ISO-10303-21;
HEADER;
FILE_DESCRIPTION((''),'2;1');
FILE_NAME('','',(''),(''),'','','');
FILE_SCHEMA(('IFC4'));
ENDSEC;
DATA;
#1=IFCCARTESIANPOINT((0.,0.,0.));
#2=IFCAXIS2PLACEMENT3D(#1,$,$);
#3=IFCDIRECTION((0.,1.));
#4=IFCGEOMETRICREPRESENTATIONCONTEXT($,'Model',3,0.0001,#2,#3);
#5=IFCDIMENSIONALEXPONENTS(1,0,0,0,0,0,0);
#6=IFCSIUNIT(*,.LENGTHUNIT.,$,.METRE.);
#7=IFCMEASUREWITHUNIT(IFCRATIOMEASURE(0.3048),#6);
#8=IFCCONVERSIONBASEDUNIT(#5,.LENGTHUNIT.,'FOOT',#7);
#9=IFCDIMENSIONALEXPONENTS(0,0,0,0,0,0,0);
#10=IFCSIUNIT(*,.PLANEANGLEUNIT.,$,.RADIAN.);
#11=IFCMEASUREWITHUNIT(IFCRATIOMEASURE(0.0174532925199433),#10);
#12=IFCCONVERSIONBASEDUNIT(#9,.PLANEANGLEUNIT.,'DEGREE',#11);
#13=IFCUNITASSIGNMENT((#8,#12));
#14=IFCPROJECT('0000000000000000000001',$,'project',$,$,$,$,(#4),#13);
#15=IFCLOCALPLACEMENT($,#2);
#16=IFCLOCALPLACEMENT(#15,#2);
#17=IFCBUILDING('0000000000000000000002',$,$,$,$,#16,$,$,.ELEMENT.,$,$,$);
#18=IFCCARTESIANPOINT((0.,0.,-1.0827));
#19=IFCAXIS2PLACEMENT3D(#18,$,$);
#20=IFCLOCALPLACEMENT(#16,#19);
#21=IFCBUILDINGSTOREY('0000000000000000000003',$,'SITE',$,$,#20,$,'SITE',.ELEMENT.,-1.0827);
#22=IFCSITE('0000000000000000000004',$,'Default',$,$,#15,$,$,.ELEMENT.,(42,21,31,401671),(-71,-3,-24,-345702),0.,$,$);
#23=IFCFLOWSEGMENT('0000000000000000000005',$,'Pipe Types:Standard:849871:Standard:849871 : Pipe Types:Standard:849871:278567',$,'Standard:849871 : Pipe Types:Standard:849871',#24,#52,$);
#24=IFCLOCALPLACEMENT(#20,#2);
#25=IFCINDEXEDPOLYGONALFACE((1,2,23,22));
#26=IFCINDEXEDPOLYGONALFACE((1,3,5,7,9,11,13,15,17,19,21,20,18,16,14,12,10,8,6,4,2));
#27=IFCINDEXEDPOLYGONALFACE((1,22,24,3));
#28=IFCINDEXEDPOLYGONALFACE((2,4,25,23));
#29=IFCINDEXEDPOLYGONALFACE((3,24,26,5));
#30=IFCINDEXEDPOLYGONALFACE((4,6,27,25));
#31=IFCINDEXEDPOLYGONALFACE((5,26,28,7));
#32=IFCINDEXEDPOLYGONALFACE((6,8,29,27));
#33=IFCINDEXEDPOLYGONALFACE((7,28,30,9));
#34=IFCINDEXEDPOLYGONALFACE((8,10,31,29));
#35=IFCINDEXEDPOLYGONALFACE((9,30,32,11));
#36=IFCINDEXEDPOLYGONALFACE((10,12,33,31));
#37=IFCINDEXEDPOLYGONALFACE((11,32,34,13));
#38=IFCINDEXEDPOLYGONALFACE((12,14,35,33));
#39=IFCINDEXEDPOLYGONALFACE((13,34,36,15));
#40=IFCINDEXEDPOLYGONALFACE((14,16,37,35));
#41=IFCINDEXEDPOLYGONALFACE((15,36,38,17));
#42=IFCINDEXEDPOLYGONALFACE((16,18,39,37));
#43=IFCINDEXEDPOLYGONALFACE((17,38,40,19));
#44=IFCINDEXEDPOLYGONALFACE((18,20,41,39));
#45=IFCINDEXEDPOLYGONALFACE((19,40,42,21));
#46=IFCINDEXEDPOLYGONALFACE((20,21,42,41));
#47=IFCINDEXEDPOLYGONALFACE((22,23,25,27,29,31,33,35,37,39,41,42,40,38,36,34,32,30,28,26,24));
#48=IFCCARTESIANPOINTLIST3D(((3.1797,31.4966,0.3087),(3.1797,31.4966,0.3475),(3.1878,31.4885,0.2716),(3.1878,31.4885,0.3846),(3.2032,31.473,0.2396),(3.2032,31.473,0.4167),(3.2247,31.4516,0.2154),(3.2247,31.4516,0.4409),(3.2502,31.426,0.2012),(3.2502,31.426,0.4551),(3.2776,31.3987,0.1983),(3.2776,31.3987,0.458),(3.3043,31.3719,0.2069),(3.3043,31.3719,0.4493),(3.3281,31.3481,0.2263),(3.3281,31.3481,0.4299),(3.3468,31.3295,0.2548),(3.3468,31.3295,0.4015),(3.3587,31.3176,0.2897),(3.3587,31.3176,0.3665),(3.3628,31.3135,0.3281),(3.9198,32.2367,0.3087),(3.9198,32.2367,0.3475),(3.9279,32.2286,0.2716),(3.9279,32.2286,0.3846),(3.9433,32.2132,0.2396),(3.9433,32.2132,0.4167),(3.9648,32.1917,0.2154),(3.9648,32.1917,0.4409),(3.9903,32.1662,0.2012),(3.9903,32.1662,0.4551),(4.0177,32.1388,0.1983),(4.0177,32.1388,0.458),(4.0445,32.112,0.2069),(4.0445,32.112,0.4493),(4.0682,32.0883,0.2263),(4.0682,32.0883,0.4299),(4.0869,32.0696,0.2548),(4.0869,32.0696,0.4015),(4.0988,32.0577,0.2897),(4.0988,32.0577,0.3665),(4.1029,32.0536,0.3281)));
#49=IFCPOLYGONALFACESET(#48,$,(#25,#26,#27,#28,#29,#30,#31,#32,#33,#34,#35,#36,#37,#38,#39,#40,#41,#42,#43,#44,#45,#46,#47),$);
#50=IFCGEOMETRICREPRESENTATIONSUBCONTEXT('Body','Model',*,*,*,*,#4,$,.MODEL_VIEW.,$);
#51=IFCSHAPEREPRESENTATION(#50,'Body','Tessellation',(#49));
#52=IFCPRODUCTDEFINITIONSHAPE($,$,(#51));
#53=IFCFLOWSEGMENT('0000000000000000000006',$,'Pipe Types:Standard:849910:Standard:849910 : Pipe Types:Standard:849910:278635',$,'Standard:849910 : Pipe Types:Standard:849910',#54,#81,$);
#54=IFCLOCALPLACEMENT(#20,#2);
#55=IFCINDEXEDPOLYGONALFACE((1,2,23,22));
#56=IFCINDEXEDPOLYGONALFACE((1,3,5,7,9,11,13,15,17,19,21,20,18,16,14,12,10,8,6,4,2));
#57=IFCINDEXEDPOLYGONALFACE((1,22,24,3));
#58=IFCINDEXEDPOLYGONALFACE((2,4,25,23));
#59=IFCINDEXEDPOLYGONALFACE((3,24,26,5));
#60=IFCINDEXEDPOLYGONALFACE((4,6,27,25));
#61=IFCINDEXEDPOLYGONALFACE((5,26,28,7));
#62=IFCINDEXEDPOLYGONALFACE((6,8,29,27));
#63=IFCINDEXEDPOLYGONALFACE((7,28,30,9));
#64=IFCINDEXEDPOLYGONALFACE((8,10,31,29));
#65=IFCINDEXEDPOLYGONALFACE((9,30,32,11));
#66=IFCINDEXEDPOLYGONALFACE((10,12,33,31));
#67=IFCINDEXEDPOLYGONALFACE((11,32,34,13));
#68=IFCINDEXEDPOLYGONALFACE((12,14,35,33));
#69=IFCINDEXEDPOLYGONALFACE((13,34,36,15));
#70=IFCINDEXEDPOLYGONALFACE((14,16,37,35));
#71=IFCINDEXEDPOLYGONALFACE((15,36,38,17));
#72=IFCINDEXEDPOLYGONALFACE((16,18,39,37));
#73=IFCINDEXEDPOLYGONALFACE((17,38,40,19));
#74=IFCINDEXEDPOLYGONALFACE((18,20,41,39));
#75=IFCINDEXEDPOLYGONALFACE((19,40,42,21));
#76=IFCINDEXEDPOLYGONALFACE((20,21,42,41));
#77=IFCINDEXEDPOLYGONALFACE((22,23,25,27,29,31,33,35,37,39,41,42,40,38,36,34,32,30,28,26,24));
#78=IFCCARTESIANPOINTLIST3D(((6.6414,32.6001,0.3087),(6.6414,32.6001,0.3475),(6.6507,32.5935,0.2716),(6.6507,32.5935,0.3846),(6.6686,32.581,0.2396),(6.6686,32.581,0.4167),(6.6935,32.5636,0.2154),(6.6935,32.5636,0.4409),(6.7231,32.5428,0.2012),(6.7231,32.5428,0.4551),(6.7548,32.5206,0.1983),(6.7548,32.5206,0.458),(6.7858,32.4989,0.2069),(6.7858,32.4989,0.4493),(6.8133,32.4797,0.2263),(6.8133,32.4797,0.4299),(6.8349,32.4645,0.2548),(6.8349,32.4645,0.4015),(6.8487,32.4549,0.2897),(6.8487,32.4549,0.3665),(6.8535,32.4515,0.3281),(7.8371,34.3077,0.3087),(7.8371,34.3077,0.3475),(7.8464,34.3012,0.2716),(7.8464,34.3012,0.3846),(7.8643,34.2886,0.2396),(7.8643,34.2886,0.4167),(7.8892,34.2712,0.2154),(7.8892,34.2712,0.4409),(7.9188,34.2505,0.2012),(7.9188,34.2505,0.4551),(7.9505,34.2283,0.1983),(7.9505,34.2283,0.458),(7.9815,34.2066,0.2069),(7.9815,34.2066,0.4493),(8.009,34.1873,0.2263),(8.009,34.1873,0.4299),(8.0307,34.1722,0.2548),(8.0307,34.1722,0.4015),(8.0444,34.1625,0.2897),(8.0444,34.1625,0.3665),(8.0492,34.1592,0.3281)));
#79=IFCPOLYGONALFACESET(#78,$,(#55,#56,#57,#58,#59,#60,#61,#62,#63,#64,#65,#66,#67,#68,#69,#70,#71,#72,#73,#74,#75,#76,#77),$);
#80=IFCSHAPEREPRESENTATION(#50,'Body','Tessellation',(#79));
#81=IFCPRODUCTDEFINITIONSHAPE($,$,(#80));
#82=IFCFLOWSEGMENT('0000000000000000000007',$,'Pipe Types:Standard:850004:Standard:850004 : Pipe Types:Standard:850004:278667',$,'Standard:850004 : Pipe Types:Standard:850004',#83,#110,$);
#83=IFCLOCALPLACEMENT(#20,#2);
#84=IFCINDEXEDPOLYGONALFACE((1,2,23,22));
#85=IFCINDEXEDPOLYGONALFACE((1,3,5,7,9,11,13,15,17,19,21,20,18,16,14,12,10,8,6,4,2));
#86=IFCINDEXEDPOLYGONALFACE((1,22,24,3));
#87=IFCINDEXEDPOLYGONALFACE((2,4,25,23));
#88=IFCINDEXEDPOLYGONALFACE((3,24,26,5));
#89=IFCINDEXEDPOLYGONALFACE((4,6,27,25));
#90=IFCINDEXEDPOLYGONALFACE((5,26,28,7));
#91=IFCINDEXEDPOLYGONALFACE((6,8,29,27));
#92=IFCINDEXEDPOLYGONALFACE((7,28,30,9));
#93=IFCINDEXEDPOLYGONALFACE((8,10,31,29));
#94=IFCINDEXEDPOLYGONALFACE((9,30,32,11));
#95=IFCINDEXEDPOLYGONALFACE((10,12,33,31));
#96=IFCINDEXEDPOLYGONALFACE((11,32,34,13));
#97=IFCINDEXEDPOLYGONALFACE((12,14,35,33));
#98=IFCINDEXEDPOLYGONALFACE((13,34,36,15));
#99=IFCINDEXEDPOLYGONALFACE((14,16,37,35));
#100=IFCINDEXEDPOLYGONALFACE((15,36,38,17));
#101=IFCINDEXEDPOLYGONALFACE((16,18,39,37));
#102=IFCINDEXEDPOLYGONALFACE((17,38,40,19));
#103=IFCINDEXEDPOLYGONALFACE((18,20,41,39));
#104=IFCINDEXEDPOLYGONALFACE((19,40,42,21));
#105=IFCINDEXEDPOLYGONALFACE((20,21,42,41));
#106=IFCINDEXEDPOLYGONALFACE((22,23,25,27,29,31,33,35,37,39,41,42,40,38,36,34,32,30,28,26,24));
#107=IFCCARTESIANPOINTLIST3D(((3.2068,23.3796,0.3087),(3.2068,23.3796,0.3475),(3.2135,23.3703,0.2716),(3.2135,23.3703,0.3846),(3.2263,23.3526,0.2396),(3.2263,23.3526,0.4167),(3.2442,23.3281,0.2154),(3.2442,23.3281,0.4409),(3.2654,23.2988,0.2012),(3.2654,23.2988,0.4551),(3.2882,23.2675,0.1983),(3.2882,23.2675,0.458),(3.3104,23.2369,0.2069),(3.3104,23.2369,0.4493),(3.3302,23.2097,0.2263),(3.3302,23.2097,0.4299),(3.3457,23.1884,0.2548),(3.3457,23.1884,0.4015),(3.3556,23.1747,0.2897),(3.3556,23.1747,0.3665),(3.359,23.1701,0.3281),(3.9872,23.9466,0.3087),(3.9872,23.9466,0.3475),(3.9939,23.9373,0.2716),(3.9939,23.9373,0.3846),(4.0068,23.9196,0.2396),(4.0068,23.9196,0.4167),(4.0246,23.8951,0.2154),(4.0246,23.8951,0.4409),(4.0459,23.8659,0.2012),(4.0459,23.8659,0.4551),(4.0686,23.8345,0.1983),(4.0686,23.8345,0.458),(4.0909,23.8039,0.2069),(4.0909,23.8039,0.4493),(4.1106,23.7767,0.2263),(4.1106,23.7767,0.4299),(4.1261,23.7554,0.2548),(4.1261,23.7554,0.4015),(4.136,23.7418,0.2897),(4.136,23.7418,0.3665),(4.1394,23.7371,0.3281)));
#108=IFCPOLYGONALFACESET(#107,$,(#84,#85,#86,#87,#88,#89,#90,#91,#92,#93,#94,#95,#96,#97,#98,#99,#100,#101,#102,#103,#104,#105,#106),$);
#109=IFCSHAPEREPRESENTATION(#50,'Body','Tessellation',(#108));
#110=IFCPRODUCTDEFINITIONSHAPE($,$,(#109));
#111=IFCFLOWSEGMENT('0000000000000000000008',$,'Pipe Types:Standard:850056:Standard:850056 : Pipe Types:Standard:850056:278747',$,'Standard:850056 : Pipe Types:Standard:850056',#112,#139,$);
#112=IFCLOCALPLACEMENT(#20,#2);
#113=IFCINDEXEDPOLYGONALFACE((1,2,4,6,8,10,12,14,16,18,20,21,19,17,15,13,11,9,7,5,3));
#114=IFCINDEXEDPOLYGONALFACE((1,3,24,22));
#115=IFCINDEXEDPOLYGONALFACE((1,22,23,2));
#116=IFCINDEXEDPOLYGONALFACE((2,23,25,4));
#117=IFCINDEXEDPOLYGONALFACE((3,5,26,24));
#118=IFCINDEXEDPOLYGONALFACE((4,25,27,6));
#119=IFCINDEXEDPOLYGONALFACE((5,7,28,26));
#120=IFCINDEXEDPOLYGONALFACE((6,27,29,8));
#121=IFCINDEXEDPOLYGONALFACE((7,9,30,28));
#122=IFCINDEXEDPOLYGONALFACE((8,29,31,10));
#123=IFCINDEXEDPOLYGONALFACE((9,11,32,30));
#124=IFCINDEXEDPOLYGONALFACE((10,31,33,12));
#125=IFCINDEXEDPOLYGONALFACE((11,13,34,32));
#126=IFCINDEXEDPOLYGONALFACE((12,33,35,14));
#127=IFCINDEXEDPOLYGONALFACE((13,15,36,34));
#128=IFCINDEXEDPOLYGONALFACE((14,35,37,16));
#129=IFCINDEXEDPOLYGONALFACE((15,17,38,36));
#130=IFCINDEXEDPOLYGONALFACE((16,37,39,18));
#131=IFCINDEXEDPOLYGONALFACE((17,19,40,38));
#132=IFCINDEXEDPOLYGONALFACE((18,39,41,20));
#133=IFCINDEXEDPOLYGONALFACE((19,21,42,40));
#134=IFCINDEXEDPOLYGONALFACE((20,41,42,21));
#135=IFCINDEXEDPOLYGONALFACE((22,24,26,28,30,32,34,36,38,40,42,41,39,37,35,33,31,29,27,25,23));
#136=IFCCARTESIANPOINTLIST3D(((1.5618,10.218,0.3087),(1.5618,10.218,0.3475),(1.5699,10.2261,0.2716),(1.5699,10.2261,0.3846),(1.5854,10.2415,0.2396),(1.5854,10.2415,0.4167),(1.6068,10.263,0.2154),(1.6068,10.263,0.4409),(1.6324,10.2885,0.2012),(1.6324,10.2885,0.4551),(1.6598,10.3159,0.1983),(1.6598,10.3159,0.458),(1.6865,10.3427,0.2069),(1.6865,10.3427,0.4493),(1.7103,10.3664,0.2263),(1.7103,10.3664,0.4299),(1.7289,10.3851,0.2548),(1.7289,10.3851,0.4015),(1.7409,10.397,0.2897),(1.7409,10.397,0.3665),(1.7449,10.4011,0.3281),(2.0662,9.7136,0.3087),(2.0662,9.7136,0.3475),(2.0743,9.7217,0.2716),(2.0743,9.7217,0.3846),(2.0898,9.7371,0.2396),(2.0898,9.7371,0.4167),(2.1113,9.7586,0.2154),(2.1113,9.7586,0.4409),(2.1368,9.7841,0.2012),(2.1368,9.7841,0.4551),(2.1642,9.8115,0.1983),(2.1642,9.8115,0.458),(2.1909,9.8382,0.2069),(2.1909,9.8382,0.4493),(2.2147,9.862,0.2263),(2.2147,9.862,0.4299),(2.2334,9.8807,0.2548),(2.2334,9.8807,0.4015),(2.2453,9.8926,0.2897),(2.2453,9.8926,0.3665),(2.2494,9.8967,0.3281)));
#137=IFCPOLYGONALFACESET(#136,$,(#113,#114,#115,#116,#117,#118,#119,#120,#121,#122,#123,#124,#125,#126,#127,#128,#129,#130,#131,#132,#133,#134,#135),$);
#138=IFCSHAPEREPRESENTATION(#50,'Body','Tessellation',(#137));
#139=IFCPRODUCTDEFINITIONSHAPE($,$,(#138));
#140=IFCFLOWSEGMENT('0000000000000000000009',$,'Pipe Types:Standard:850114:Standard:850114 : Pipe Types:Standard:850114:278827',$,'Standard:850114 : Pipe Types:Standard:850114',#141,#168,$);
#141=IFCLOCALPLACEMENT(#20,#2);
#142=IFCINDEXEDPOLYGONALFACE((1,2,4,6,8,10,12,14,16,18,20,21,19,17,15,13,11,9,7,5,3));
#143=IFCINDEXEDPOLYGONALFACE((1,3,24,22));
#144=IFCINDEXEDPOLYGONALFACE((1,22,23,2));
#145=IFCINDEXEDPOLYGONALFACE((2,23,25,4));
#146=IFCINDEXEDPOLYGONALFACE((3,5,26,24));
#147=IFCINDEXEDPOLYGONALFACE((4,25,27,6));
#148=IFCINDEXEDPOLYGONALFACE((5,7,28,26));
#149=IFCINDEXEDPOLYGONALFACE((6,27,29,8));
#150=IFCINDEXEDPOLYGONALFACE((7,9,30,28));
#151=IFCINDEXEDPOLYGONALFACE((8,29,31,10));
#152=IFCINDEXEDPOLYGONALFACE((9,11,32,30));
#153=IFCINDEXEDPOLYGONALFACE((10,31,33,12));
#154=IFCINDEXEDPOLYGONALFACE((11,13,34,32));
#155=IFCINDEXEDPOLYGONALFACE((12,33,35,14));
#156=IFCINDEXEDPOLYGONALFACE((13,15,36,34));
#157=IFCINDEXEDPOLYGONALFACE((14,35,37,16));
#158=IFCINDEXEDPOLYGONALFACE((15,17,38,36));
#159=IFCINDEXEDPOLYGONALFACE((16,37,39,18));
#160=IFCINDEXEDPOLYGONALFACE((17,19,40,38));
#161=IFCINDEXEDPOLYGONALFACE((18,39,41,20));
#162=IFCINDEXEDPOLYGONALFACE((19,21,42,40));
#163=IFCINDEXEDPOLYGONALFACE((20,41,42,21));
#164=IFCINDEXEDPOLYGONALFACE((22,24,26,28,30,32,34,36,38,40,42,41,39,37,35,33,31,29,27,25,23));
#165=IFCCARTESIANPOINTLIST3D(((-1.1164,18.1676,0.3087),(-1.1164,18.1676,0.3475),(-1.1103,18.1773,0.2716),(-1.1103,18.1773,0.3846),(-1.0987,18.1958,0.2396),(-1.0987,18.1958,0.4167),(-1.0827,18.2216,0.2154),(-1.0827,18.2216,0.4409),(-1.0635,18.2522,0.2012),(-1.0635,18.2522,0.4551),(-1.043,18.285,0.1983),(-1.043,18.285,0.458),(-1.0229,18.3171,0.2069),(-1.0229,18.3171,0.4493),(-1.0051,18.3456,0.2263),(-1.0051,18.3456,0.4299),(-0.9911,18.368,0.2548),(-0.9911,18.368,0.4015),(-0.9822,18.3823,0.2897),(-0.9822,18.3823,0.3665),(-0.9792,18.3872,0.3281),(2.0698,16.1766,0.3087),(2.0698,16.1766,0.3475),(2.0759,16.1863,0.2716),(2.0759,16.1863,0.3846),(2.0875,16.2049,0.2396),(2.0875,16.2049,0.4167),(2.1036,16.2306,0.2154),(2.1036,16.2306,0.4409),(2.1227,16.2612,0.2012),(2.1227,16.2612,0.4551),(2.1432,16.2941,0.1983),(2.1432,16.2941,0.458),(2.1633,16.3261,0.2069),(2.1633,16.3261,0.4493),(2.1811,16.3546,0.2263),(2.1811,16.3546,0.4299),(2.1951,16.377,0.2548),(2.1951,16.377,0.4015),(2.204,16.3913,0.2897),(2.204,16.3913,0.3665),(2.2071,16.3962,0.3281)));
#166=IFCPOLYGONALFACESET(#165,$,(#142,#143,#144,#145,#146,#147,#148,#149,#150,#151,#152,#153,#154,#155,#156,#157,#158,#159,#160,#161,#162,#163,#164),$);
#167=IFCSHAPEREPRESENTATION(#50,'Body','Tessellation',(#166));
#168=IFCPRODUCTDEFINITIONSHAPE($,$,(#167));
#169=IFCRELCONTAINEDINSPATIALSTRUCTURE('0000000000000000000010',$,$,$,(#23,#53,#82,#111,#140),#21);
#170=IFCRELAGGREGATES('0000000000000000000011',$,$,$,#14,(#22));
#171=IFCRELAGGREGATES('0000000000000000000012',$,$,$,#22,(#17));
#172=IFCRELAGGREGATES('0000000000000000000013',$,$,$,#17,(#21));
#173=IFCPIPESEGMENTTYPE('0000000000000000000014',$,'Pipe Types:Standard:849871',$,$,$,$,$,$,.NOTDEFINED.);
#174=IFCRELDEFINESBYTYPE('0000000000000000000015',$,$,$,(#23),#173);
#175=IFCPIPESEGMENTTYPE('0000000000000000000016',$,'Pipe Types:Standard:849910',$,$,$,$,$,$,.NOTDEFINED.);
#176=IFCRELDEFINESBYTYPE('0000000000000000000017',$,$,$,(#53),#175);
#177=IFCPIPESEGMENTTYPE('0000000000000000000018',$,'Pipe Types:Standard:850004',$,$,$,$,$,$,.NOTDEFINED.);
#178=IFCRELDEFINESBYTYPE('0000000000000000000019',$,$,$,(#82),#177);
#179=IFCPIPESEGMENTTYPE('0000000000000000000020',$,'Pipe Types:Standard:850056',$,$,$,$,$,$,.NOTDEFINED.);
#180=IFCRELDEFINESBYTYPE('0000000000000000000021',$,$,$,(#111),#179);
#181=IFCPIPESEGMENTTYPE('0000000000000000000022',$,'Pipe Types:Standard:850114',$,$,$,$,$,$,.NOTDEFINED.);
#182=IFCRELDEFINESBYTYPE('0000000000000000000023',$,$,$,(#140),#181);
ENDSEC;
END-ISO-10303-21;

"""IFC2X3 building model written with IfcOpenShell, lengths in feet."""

from ifc_helpers import new_model, entity, si_unit, converted_unit, direction, frame, frame_2d, origin, place, context, subcontext, project, spatial, circle, extrude, source, transform, mapped, type_object, type_shapes, element, save


model = new_model("IFC2X3")

# Units and contexts
model_context = context("Model", 3, precision=0.0001, world=origin(), true_north=direction((0.0, 1.0)))
body_context = subcontext(model_context, "Body", "Model", "MODEL_VIEW")
ifc_project = project(units=[converted_unit("LENGTHUNIT", "FOOT", entity("IfcRatioMeasure", 0.3048), si_unit("LENGTHUNIT", "METRE"), dimensions=[1, 0, 0, 0, 0, 0, 0]), converted_unit("PLANEANGLEUNIT", "DEGREE", entity("IfcRatioMeasure", 0.0174532925199433), si_unit("PLANEANGLEUNIT", "RADIAN"), dimensions=[0, 0, 0, 0, 0, 0, 0])], contexts=[model_context])

# Site, building, storey
site_placement = place(None, origin())
site = spatial("IfcSite", under=ifc_project, at=site_placement, Name="Default", CompositionType="ELEMENT", RefLatitude=(42, 21, 31, 401671), RefLongitude=(-71, -3, -24, -345702), RefElevation=0.0)
building_placement = place(site_placement, origin())
building = spatial("IfcBuilding", under=site, at=building_placement, CompositionType="ELEMENT")
storey_placement = place(building_placement, frame((0.0, 0.0, -1.0827)))
storey = spatial("IfcBuildingStorey", under=building, at=storey_placement, Name="SITE", LongName="SITE", CompositionType="ELEMENT", Elevation=-1.0827)

# Flow segments
pipe_segment_type_1 = type_object("IfcPipeSegmentType", Name="Pipe Types:Standard:849871", PredefinedType="NOTDEFINED")
shared_shape_1 = source(origin(), body_context, "Body", "SweptSolid", [
    extrude(circle(Radius=0.1302, at=frame_2d((0.0, 0.0), x_axis=(1.0, 0.0))), frame((3.2707, 31.4055, -0.7546), z_axis=(0.707107, 0.707107, 0.0), x_axis=(0.707107, -0.707107, 0.0)), (0.0, 0.0, 1.0), 1.0467),
])
type_shapes(pipe_segment_type_1, [shared_shape_1])
flow_segment_1_placement = place(storey_placement, frame((0.0, 0.0, 1.0827)))
element("IfcFlowSegment", 1, at=flow_segment_1_placement, inside=storey, type_object=pipe_segment_type_1, Name="Pipe Types:Standard:849871:Standard:849871 : Pipe Types:Standard:849871:278567", ObjectType="Standard:849871 : Pipe Types:Standard:849871", context=body_context, shape_type="MappedRepresentation", body=[
    mapped(shared_shape_1, transform((0.0, 0.0, 0.0), scale=1.0)),
])
pipe_segment_type_2 = type_object("IfcPipeSegmentType", Name="Pipe Types:Standard:849910", PredefinedType="NOTDEFINED")
shared_shape_2 = source(origin(), body_context, "Body", "SweptSolid", [
    extrude(circle(Radius=0.1302, at=frame_2d((0.0, 0.0), x_axis=(1.0, 0.0))), frame((6.7468, 32.5262, -0.7546), z_axis=(0.573576, 0.819152, 0.0), x_axis=(0.819152, -0.573576, 0.0)), (0.0, 0.0, 1.0), 2.0846),
])
type_shapes(pipe_segment_type_2, [shared_shape_2])
flow_segment_2_placement = place(storey_placement, frame((0.0, 0.0, 1.0827)))
element("IfcFlowSegment", 2, at=flow_segment_2_placement, inside=storey, type_object=pipe_segment_type_2, Name="Pipe Types:Standard:849910:Standard:849910 : Pipe Types:Standard:849910:278635", ObjectType="Standard:849910 : Pipe Types:Standard:849910", context=body_context, shape_type="MappedRepresentation", body=[
    mapped(shared_shape_2, transform((0.0, 0.0, 0.0), scale=1.0)),
])
pipe_segment_type_3 = type_object("IfcPipeSegmentType", Name="Pipe Types:Standard:850004", PredefinedType="NOTDEFINED")
shared_shape_3 = source(origin(), body_context, "Body", "SweptSolid", [
    extrude(circle(Radius=0.1302, at=frame_2d((0.0, 0.0), x_axis=(1.0, 0.0))), frame((3.2824, 23.2754, -0.7546), z_axis=(0.809017, 0.587785, 0.0), x_axis=(0.587785, -0.809017, 0.0)), (0.0, 0.0, 1.0), 0.9647),
])
type_shapes(pipe_segment_type_3, [shared_shape_3])
flow_segment_3_placement = place(storey_placement, frame((0.0, 0.0, 1.0827)))
element("IfcFlowSegment", 3, at=flow_segment_3_placement, inside=storey, type_object=pipe_segment_type_3, Name="Pipe Types:Standard:850004:Standard:850004 : Pipe Types:Standard:850004:278667", ObjectType="Standard:850004 : Pipe Types:Standard:850004", context=body_context, shape_type="MappedRepresentation", body=[
    mapped(shared_shape_3, transform((0.0, 0.0, 0.0), scale=1.0)),
])
pipe_segment_type_4 = type_object("IfcPipeSegmentType", Name="Pipe Types:Standard:850056", PredefinedType="NOTDEFINED")
shared_shape_4 = source(origin(), body_context, "Body", "SweptSolid", [
    extrude(circle(Radius=0.1302, at=frame_2d((0.0, 0.0), x_axis=(1.0, 0.0))), frame((1.6529, 10.309, -0.7546), z_axis=(0.707107, -0.707107, 0.0), x_axis=(0.707107, 0.707107, 0.0)), (0.0, 0.0, 1.0), 0.7133),
])
type_shapes(pipe_segment_type_4, [shared_shape_4])
flow_segment_4_placement = place(storey_placement, frame((0.0, 0.0, 1.0827)))
element("IfcFlowSegment", 4, at=flow_segment_4_placement, inside=storey, type_object=pipe_segment_type_4, Name="Pipe Types:Standard:850056:Standard:850056 : Pipe Types:Standard:850056:278747", ObjectType="Standard:850056 : Pipe Types:Standard:850056", context=body_context, shape_type="MappedRepresentation", body=[
    mapped(shared_shape_4, transform((0.0, 0.0, 0.0), scale=1.0)),
])
pipe_segment_type_5 = type_object("IfcPipeSegmentType", Name="Pipe Types:Standard:850114", PredefinedType="NOTDEFINED")
shared_shape_5 = source(origin(), body_context, "Body", "SweptSolid", [
    extrude(circle(Radius=0.1302, at=frame_2d((0.0, 0.0), x_axis=(1.0, 0.0))), frame((-1.0482, 18.2768, -0.7546), z_axis=(0.848048, -0.529919, 0.0), x_axis=(0.529919, 0.848048, 0.0)), (0.0, 0.0, 1.0), 3.7571),
])
type_shapes(pipe_segment_type_5, [shared_shape_5])
flow_segment_5_placement = place(storey_placement, frame((0.0, 0.0, 1.0827)))
element("IfcFlowSegment", 5, at=flow_segment_5_placement, inside=storey, type_object=pipe_segment_type_5, Name="Pipe Types:Standard:850114:Standard:850114 : Pipe Types:Standard:850114:278827", ObjectType="Standard:850114 : Pipe Types:Standard:850114", context=body_context, shape_type="MappedRepresentation", body=[
    mapped(shared_shape_5, transform((0.0, 0.0, 0.0), scale=1.0)),
])

save(model, "model.ifc")
